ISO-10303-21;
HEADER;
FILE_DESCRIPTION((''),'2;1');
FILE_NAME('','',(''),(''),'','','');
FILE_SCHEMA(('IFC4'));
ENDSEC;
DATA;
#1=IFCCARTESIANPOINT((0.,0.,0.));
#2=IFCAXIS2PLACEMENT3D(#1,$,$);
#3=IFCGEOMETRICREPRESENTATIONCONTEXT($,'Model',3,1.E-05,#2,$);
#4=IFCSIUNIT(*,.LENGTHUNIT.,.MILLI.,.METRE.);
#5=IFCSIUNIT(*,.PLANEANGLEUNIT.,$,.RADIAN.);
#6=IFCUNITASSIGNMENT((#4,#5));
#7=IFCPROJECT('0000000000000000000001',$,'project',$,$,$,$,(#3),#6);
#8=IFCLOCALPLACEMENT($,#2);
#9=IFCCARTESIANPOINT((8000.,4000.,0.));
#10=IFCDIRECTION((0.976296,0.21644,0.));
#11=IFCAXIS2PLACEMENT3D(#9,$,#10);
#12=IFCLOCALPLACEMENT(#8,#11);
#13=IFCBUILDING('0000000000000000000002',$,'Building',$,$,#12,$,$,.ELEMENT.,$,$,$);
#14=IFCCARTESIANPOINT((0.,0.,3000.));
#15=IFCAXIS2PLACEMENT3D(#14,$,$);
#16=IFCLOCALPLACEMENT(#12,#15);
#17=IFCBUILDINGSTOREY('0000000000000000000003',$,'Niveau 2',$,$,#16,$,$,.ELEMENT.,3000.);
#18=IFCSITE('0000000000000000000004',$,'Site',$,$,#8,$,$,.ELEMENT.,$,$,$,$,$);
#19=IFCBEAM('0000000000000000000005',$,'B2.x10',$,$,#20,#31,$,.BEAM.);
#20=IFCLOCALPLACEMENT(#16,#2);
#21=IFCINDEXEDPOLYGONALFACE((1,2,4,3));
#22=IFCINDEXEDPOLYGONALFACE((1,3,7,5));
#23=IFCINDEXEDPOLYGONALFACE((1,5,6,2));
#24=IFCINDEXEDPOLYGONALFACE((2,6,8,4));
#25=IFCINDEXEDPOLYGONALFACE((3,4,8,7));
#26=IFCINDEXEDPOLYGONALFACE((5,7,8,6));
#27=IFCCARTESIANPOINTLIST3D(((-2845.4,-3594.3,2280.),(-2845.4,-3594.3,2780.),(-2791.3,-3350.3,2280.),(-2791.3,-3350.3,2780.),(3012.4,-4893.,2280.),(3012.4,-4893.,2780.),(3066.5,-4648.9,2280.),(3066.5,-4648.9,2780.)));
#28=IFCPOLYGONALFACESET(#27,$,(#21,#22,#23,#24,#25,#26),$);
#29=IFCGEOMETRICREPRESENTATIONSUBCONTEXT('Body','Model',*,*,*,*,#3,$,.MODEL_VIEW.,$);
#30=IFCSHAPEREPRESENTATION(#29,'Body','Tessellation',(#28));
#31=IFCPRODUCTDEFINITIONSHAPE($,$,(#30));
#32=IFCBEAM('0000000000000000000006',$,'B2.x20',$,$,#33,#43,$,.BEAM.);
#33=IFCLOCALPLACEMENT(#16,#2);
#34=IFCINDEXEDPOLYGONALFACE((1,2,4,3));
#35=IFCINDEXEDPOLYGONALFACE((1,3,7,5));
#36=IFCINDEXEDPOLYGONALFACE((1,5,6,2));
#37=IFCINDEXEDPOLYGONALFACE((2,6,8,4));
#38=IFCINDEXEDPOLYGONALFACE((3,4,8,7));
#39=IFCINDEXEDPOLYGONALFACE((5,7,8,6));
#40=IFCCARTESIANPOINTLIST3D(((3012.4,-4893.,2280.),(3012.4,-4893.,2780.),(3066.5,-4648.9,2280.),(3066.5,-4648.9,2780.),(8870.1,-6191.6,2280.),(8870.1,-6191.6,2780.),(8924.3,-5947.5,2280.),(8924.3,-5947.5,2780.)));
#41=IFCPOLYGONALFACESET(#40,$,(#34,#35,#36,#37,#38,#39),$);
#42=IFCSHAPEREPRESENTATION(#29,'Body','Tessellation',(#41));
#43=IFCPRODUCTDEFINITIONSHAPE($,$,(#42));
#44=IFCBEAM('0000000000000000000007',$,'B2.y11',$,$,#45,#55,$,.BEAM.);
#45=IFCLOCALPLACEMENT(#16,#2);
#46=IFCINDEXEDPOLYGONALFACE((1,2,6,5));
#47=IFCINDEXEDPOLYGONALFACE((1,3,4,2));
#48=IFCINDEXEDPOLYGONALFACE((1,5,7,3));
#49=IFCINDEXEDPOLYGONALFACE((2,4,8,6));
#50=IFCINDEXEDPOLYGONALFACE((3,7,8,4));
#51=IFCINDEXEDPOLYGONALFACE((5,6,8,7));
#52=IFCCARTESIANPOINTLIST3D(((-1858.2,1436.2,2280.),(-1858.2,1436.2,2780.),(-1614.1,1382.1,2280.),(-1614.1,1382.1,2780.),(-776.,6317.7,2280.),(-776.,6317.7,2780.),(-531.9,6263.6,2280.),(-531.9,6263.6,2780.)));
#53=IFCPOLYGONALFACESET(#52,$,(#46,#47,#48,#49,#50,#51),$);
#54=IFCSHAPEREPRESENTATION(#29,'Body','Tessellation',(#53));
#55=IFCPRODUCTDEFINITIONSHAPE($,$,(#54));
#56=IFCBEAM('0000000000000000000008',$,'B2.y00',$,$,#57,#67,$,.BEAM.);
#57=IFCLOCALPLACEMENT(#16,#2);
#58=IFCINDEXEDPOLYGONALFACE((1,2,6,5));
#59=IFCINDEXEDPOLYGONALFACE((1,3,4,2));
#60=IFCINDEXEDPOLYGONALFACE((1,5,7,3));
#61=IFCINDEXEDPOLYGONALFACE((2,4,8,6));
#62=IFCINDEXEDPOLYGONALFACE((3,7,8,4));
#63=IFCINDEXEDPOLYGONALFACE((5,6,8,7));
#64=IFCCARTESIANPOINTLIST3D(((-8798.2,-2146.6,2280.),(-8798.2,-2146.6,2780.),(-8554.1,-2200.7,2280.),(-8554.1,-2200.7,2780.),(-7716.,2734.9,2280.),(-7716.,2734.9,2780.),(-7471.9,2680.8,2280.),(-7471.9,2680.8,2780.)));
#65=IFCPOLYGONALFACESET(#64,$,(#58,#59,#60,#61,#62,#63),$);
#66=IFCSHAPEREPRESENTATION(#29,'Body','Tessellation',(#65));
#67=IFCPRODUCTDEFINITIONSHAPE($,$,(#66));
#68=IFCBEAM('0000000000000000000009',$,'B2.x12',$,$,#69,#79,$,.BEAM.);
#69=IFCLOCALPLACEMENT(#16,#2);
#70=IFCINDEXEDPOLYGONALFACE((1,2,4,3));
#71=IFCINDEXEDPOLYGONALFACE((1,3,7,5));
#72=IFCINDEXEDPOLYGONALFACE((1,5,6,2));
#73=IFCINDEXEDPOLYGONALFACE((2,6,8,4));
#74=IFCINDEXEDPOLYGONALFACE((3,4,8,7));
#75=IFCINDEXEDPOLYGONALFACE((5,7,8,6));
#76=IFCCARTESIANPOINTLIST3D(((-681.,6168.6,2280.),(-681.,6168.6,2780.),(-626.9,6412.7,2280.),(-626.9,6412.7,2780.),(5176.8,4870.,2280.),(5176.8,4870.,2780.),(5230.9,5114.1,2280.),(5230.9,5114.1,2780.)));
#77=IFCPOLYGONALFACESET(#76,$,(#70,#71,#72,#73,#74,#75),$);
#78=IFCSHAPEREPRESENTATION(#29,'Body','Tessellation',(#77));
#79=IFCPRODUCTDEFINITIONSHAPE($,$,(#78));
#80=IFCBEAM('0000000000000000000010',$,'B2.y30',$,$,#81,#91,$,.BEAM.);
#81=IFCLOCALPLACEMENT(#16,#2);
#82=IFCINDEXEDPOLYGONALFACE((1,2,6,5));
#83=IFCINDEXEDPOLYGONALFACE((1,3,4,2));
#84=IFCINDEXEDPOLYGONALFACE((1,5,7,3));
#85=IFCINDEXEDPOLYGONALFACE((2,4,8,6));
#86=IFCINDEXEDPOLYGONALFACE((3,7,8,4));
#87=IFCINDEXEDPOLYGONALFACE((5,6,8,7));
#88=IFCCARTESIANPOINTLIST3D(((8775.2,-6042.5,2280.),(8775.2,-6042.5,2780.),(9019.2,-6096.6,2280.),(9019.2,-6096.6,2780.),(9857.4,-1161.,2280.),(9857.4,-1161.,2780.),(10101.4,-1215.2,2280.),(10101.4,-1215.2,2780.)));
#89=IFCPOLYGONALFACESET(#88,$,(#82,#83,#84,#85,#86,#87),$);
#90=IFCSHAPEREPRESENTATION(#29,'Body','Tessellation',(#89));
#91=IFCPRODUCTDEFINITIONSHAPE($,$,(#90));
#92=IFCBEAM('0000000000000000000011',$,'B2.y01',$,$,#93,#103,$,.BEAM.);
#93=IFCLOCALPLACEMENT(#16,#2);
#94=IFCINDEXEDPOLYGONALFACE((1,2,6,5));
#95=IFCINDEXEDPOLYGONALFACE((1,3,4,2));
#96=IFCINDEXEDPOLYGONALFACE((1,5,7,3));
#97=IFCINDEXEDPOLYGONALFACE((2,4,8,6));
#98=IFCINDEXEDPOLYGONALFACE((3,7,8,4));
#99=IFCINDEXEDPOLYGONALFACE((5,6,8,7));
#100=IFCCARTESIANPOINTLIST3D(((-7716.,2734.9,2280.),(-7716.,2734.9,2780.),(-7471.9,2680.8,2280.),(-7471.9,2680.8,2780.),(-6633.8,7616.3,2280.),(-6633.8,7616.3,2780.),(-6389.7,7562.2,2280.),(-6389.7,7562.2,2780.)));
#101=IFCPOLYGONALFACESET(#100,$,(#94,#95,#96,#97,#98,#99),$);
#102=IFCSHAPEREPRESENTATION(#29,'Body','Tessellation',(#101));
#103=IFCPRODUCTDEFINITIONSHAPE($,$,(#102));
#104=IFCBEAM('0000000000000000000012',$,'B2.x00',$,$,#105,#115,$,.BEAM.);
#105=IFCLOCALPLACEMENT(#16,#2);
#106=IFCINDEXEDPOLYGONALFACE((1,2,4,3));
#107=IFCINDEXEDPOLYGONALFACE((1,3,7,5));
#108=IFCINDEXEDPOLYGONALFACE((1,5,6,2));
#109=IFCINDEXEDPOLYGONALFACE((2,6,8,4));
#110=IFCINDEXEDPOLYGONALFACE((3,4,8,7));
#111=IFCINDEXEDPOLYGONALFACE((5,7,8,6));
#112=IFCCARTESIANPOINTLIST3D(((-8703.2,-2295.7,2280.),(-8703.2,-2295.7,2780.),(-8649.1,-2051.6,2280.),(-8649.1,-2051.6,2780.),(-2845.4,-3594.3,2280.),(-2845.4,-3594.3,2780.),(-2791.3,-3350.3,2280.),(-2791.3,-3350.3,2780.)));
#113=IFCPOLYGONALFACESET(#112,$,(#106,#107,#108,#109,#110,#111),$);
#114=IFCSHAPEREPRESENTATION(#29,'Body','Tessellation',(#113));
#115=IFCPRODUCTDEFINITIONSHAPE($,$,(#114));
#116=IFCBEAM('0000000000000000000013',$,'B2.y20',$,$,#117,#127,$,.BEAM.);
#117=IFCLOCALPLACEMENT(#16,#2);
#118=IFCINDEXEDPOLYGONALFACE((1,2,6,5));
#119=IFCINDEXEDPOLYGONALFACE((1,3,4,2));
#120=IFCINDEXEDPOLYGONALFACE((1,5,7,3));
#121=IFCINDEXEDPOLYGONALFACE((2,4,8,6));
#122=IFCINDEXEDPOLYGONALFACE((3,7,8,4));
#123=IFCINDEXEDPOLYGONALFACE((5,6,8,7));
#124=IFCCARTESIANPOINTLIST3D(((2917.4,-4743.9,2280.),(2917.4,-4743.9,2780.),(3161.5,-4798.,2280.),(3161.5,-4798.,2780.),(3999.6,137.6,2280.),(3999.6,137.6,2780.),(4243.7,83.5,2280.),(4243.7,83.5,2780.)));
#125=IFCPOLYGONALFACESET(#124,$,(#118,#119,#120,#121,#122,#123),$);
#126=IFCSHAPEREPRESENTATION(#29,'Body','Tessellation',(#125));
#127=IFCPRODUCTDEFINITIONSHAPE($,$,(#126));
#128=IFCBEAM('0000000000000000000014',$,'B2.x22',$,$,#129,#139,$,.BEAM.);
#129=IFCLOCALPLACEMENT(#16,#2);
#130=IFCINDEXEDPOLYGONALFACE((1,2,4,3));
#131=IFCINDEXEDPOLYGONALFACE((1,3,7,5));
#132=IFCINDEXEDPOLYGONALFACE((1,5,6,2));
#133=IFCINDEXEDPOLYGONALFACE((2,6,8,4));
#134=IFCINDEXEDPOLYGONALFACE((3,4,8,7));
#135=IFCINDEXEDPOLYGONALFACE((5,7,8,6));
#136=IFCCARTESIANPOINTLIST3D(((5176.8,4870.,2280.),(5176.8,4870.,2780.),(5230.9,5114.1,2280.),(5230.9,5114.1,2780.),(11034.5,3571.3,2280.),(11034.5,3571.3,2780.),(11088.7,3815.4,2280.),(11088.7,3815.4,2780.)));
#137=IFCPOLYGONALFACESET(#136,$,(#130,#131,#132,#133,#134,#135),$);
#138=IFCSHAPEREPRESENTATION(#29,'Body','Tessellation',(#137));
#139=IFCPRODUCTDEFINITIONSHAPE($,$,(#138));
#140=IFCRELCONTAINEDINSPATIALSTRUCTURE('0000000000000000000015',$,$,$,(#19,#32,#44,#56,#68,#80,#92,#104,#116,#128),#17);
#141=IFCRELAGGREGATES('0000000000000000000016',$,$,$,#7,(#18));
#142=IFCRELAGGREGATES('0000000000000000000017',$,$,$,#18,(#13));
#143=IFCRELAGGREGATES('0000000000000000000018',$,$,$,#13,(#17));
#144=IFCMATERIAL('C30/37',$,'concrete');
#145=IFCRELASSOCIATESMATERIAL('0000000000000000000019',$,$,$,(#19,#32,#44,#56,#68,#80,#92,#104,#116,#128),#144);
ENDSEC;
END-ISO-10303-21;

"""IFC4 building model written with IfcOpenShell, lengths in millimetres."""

from ifc_helpers import new_model, si_unit, frame, origin, place, context, subcontext, project, spatial, rectangle, extrude, material, element, save


model = new_model("IFC4")

# Units and contexts
model_context = context("Model", 3, precision=1e-05, world=origin())
body_context = subcontext(model_context, "Body", "Model", "MODEL_VIEW")
ifc_project = project(units=[si_unit("LENGTHUNIT", "METRE", prefix="MILLI"), si_unit("PLANEANGLEUNIT", "RADIAN")], contexts=[model_context])

# Site, building, storey
site_placement = place(None, origin())
site = spatial("IfcSite", under=ifc_project, at=site_placement, Name="Site", CompositionType="ELEMENT")
building_placement = place(site_placement, frame((8000.0, 4000.0, 0.0), x_axis=(0.976296, 0.21644, 0.0)))
building = spatial("IfcBuilding", under=site, at=building_placement, Name="Building", CompositionType="ELEMENT")
storey_placement = place(building_placement, frame((0.0, 0.0, 3000.0)))
storey = spatial("IfcBuildingStorey", under=building, at=storey_placement, Name="Niveau 2", CompositionType="ELEMENT", Elevation=3000.0)

# Shared definitions
ifc_material = material(Name="C30/37", Category="concrete")

# Beams
for number, where, z_axis, x_axis, name in (
    (1, (-2818.4, -3472.3, 2530.0), (0.976296, -0.21644, 0.0), (0.21644, 0.976296, 0.0), "B2.x10"),
    (2, (3039.4, -4770.9, 2530.0), (0.976296, -0.21644, 0.0), (0.21644, 0.976296, 0.0), "B2.x20"),
):
    element("IfcBeam", number, at=place(storey_placement, frame(where, z_axis=z_axis, x_axis=x_axis)), inside=storey, material=ifc_material, Name=name, PredefinedType="BEAM", context=body_context, shape_type="SweptSolid", body=[
        extrude(rectangle(XDim=250.0, YDim=500.0), origin(), (0.0, 0.0, 1.0), 6000.0),
    ])
for number, where, z_axis, x_axis, name in (
    (3, (-1736.2, 1409.2, 2530.0), (0.21644, 0.976296, 0.0), (-0.976296, 0.21644, 0.0), "B2.y11"),
    (4, (-8676.1, -2173.7, 2530.0), (0.21644, 0.976296, 0.0), (-0.976296, 0.21644, 0.0), "B2.y00"),
):
    element("IfcBeam", number, at=place(storey_placement, frame(where, z_axis=z_axis, x_axis=x_axis)), inside=storey, material=ifc_material, Name=name, PredefinedType="BEAM", context=body_context, shape_type="SweptSolid", body=[
        extrude(rectangle(XDim=250.0, YDim=500.0), origin(), (0.0, 0.0, 1.0), 5000.0),
    ])
beam_1_placement = place(storey_placement, frame((-654.0, 6290.7, 2530.0), z_axis=(0.976296, -0.21644, 0.0), x_axis=(0.21644, 0.976296, 0.0)))
element("IfcBeam", 5, at=beam_1_placement, inside=storey, material=ifc_material, Name="B2.x12", PredefinedType="BEAM", context=body_context, shape_type="SweptSolid", body=[
    extrude(rectangle(XDim=250.0, YDim=500.0), origin(), (0.0, 0.0, 1.0), 6000.0),
])
for number, where, z_axis, x_axis, name in (
    (6, (8897.2, -6069.6, 2530.0), (0.21644, 0.976296, 0.0), (-0.976296, 0.21644, 0.0), "B2.y30"),
    (7, (-7593.9, 2707.8, 2530.0), (0.21644, 0.976296, 0.0), (-0.976296, 0.21644, 0.0), "B2.y01"),
):
    element("IfcBeam", number, at=place(storey_placement, frame(where, z_axis=z_axis, x_axis=x_axis)), inside=storey, material=ifc_material, Name=name, PredefinedType="BEAM", context=body_context, shape_type="SweptSolid", body=[
        extrude(rectangle(XDim=250.0, YDim=500.0), origin(), (0.0, 0.0, 1.0), 5000.0),
    ])
beam_2_placement = place(storey_placement, frame((-8676.1, -2173.7, 2530.0), z_axis=(0.976296, -0.21644, 0.0), x_axis=(0.21644, 0.976296, 0.0)))
element("IfcBeam", 8, at=beam_2_placement, inside=storey, material=ifc_material, Name="B2.x00", PredefinedType="BEAM", context=body_context, shape_type="SweptSolid", body=[
    extrude(rectangle(XDim=250.0, YDim=500.0), origin(), (0.0, 0.0, 1.0), 6000.0),
])
beam_3_placement = place(storey_placement, frame((3039.4, -4770.9, 2530.0), z_axis=(0.21644, 0.976296, 0.0), x_axis=(-0.976296, 0.21644, 0.0)))
element("IfcBeam", 9, at=beam_3_placement, inside=storey, material=ifc_material, Name="B2.y20", PredefinedType="BEAM", context=body_context, shape_type="SweptSolid", body=[
    extrude(rectangle(XDim=250.0, YDim=500.0), origin(), (0.0, 0.0, 1.0), 5000.0),
])
beam_4_placement = place(storey_placement, frame((5203.8, 4992.0, 2530.0), z_axis=(0.976296, -0.21644, 0.0), x_axis=(0.21644, 0.976296, 0.0)))
element("IfcBeam", 10, at=beam_4_placement, inside=storey, material=ifc_material, Name="B2.x22", PredefinedType="BEAM", context=body_context, shape_type="SweptSolid", body=[
    extrude(rectangle(XDim=250.0, YDim=500.0), origin(), (0.0, 0.0, 1.0), 6000.0),
])

save(model, "model.ifc")
